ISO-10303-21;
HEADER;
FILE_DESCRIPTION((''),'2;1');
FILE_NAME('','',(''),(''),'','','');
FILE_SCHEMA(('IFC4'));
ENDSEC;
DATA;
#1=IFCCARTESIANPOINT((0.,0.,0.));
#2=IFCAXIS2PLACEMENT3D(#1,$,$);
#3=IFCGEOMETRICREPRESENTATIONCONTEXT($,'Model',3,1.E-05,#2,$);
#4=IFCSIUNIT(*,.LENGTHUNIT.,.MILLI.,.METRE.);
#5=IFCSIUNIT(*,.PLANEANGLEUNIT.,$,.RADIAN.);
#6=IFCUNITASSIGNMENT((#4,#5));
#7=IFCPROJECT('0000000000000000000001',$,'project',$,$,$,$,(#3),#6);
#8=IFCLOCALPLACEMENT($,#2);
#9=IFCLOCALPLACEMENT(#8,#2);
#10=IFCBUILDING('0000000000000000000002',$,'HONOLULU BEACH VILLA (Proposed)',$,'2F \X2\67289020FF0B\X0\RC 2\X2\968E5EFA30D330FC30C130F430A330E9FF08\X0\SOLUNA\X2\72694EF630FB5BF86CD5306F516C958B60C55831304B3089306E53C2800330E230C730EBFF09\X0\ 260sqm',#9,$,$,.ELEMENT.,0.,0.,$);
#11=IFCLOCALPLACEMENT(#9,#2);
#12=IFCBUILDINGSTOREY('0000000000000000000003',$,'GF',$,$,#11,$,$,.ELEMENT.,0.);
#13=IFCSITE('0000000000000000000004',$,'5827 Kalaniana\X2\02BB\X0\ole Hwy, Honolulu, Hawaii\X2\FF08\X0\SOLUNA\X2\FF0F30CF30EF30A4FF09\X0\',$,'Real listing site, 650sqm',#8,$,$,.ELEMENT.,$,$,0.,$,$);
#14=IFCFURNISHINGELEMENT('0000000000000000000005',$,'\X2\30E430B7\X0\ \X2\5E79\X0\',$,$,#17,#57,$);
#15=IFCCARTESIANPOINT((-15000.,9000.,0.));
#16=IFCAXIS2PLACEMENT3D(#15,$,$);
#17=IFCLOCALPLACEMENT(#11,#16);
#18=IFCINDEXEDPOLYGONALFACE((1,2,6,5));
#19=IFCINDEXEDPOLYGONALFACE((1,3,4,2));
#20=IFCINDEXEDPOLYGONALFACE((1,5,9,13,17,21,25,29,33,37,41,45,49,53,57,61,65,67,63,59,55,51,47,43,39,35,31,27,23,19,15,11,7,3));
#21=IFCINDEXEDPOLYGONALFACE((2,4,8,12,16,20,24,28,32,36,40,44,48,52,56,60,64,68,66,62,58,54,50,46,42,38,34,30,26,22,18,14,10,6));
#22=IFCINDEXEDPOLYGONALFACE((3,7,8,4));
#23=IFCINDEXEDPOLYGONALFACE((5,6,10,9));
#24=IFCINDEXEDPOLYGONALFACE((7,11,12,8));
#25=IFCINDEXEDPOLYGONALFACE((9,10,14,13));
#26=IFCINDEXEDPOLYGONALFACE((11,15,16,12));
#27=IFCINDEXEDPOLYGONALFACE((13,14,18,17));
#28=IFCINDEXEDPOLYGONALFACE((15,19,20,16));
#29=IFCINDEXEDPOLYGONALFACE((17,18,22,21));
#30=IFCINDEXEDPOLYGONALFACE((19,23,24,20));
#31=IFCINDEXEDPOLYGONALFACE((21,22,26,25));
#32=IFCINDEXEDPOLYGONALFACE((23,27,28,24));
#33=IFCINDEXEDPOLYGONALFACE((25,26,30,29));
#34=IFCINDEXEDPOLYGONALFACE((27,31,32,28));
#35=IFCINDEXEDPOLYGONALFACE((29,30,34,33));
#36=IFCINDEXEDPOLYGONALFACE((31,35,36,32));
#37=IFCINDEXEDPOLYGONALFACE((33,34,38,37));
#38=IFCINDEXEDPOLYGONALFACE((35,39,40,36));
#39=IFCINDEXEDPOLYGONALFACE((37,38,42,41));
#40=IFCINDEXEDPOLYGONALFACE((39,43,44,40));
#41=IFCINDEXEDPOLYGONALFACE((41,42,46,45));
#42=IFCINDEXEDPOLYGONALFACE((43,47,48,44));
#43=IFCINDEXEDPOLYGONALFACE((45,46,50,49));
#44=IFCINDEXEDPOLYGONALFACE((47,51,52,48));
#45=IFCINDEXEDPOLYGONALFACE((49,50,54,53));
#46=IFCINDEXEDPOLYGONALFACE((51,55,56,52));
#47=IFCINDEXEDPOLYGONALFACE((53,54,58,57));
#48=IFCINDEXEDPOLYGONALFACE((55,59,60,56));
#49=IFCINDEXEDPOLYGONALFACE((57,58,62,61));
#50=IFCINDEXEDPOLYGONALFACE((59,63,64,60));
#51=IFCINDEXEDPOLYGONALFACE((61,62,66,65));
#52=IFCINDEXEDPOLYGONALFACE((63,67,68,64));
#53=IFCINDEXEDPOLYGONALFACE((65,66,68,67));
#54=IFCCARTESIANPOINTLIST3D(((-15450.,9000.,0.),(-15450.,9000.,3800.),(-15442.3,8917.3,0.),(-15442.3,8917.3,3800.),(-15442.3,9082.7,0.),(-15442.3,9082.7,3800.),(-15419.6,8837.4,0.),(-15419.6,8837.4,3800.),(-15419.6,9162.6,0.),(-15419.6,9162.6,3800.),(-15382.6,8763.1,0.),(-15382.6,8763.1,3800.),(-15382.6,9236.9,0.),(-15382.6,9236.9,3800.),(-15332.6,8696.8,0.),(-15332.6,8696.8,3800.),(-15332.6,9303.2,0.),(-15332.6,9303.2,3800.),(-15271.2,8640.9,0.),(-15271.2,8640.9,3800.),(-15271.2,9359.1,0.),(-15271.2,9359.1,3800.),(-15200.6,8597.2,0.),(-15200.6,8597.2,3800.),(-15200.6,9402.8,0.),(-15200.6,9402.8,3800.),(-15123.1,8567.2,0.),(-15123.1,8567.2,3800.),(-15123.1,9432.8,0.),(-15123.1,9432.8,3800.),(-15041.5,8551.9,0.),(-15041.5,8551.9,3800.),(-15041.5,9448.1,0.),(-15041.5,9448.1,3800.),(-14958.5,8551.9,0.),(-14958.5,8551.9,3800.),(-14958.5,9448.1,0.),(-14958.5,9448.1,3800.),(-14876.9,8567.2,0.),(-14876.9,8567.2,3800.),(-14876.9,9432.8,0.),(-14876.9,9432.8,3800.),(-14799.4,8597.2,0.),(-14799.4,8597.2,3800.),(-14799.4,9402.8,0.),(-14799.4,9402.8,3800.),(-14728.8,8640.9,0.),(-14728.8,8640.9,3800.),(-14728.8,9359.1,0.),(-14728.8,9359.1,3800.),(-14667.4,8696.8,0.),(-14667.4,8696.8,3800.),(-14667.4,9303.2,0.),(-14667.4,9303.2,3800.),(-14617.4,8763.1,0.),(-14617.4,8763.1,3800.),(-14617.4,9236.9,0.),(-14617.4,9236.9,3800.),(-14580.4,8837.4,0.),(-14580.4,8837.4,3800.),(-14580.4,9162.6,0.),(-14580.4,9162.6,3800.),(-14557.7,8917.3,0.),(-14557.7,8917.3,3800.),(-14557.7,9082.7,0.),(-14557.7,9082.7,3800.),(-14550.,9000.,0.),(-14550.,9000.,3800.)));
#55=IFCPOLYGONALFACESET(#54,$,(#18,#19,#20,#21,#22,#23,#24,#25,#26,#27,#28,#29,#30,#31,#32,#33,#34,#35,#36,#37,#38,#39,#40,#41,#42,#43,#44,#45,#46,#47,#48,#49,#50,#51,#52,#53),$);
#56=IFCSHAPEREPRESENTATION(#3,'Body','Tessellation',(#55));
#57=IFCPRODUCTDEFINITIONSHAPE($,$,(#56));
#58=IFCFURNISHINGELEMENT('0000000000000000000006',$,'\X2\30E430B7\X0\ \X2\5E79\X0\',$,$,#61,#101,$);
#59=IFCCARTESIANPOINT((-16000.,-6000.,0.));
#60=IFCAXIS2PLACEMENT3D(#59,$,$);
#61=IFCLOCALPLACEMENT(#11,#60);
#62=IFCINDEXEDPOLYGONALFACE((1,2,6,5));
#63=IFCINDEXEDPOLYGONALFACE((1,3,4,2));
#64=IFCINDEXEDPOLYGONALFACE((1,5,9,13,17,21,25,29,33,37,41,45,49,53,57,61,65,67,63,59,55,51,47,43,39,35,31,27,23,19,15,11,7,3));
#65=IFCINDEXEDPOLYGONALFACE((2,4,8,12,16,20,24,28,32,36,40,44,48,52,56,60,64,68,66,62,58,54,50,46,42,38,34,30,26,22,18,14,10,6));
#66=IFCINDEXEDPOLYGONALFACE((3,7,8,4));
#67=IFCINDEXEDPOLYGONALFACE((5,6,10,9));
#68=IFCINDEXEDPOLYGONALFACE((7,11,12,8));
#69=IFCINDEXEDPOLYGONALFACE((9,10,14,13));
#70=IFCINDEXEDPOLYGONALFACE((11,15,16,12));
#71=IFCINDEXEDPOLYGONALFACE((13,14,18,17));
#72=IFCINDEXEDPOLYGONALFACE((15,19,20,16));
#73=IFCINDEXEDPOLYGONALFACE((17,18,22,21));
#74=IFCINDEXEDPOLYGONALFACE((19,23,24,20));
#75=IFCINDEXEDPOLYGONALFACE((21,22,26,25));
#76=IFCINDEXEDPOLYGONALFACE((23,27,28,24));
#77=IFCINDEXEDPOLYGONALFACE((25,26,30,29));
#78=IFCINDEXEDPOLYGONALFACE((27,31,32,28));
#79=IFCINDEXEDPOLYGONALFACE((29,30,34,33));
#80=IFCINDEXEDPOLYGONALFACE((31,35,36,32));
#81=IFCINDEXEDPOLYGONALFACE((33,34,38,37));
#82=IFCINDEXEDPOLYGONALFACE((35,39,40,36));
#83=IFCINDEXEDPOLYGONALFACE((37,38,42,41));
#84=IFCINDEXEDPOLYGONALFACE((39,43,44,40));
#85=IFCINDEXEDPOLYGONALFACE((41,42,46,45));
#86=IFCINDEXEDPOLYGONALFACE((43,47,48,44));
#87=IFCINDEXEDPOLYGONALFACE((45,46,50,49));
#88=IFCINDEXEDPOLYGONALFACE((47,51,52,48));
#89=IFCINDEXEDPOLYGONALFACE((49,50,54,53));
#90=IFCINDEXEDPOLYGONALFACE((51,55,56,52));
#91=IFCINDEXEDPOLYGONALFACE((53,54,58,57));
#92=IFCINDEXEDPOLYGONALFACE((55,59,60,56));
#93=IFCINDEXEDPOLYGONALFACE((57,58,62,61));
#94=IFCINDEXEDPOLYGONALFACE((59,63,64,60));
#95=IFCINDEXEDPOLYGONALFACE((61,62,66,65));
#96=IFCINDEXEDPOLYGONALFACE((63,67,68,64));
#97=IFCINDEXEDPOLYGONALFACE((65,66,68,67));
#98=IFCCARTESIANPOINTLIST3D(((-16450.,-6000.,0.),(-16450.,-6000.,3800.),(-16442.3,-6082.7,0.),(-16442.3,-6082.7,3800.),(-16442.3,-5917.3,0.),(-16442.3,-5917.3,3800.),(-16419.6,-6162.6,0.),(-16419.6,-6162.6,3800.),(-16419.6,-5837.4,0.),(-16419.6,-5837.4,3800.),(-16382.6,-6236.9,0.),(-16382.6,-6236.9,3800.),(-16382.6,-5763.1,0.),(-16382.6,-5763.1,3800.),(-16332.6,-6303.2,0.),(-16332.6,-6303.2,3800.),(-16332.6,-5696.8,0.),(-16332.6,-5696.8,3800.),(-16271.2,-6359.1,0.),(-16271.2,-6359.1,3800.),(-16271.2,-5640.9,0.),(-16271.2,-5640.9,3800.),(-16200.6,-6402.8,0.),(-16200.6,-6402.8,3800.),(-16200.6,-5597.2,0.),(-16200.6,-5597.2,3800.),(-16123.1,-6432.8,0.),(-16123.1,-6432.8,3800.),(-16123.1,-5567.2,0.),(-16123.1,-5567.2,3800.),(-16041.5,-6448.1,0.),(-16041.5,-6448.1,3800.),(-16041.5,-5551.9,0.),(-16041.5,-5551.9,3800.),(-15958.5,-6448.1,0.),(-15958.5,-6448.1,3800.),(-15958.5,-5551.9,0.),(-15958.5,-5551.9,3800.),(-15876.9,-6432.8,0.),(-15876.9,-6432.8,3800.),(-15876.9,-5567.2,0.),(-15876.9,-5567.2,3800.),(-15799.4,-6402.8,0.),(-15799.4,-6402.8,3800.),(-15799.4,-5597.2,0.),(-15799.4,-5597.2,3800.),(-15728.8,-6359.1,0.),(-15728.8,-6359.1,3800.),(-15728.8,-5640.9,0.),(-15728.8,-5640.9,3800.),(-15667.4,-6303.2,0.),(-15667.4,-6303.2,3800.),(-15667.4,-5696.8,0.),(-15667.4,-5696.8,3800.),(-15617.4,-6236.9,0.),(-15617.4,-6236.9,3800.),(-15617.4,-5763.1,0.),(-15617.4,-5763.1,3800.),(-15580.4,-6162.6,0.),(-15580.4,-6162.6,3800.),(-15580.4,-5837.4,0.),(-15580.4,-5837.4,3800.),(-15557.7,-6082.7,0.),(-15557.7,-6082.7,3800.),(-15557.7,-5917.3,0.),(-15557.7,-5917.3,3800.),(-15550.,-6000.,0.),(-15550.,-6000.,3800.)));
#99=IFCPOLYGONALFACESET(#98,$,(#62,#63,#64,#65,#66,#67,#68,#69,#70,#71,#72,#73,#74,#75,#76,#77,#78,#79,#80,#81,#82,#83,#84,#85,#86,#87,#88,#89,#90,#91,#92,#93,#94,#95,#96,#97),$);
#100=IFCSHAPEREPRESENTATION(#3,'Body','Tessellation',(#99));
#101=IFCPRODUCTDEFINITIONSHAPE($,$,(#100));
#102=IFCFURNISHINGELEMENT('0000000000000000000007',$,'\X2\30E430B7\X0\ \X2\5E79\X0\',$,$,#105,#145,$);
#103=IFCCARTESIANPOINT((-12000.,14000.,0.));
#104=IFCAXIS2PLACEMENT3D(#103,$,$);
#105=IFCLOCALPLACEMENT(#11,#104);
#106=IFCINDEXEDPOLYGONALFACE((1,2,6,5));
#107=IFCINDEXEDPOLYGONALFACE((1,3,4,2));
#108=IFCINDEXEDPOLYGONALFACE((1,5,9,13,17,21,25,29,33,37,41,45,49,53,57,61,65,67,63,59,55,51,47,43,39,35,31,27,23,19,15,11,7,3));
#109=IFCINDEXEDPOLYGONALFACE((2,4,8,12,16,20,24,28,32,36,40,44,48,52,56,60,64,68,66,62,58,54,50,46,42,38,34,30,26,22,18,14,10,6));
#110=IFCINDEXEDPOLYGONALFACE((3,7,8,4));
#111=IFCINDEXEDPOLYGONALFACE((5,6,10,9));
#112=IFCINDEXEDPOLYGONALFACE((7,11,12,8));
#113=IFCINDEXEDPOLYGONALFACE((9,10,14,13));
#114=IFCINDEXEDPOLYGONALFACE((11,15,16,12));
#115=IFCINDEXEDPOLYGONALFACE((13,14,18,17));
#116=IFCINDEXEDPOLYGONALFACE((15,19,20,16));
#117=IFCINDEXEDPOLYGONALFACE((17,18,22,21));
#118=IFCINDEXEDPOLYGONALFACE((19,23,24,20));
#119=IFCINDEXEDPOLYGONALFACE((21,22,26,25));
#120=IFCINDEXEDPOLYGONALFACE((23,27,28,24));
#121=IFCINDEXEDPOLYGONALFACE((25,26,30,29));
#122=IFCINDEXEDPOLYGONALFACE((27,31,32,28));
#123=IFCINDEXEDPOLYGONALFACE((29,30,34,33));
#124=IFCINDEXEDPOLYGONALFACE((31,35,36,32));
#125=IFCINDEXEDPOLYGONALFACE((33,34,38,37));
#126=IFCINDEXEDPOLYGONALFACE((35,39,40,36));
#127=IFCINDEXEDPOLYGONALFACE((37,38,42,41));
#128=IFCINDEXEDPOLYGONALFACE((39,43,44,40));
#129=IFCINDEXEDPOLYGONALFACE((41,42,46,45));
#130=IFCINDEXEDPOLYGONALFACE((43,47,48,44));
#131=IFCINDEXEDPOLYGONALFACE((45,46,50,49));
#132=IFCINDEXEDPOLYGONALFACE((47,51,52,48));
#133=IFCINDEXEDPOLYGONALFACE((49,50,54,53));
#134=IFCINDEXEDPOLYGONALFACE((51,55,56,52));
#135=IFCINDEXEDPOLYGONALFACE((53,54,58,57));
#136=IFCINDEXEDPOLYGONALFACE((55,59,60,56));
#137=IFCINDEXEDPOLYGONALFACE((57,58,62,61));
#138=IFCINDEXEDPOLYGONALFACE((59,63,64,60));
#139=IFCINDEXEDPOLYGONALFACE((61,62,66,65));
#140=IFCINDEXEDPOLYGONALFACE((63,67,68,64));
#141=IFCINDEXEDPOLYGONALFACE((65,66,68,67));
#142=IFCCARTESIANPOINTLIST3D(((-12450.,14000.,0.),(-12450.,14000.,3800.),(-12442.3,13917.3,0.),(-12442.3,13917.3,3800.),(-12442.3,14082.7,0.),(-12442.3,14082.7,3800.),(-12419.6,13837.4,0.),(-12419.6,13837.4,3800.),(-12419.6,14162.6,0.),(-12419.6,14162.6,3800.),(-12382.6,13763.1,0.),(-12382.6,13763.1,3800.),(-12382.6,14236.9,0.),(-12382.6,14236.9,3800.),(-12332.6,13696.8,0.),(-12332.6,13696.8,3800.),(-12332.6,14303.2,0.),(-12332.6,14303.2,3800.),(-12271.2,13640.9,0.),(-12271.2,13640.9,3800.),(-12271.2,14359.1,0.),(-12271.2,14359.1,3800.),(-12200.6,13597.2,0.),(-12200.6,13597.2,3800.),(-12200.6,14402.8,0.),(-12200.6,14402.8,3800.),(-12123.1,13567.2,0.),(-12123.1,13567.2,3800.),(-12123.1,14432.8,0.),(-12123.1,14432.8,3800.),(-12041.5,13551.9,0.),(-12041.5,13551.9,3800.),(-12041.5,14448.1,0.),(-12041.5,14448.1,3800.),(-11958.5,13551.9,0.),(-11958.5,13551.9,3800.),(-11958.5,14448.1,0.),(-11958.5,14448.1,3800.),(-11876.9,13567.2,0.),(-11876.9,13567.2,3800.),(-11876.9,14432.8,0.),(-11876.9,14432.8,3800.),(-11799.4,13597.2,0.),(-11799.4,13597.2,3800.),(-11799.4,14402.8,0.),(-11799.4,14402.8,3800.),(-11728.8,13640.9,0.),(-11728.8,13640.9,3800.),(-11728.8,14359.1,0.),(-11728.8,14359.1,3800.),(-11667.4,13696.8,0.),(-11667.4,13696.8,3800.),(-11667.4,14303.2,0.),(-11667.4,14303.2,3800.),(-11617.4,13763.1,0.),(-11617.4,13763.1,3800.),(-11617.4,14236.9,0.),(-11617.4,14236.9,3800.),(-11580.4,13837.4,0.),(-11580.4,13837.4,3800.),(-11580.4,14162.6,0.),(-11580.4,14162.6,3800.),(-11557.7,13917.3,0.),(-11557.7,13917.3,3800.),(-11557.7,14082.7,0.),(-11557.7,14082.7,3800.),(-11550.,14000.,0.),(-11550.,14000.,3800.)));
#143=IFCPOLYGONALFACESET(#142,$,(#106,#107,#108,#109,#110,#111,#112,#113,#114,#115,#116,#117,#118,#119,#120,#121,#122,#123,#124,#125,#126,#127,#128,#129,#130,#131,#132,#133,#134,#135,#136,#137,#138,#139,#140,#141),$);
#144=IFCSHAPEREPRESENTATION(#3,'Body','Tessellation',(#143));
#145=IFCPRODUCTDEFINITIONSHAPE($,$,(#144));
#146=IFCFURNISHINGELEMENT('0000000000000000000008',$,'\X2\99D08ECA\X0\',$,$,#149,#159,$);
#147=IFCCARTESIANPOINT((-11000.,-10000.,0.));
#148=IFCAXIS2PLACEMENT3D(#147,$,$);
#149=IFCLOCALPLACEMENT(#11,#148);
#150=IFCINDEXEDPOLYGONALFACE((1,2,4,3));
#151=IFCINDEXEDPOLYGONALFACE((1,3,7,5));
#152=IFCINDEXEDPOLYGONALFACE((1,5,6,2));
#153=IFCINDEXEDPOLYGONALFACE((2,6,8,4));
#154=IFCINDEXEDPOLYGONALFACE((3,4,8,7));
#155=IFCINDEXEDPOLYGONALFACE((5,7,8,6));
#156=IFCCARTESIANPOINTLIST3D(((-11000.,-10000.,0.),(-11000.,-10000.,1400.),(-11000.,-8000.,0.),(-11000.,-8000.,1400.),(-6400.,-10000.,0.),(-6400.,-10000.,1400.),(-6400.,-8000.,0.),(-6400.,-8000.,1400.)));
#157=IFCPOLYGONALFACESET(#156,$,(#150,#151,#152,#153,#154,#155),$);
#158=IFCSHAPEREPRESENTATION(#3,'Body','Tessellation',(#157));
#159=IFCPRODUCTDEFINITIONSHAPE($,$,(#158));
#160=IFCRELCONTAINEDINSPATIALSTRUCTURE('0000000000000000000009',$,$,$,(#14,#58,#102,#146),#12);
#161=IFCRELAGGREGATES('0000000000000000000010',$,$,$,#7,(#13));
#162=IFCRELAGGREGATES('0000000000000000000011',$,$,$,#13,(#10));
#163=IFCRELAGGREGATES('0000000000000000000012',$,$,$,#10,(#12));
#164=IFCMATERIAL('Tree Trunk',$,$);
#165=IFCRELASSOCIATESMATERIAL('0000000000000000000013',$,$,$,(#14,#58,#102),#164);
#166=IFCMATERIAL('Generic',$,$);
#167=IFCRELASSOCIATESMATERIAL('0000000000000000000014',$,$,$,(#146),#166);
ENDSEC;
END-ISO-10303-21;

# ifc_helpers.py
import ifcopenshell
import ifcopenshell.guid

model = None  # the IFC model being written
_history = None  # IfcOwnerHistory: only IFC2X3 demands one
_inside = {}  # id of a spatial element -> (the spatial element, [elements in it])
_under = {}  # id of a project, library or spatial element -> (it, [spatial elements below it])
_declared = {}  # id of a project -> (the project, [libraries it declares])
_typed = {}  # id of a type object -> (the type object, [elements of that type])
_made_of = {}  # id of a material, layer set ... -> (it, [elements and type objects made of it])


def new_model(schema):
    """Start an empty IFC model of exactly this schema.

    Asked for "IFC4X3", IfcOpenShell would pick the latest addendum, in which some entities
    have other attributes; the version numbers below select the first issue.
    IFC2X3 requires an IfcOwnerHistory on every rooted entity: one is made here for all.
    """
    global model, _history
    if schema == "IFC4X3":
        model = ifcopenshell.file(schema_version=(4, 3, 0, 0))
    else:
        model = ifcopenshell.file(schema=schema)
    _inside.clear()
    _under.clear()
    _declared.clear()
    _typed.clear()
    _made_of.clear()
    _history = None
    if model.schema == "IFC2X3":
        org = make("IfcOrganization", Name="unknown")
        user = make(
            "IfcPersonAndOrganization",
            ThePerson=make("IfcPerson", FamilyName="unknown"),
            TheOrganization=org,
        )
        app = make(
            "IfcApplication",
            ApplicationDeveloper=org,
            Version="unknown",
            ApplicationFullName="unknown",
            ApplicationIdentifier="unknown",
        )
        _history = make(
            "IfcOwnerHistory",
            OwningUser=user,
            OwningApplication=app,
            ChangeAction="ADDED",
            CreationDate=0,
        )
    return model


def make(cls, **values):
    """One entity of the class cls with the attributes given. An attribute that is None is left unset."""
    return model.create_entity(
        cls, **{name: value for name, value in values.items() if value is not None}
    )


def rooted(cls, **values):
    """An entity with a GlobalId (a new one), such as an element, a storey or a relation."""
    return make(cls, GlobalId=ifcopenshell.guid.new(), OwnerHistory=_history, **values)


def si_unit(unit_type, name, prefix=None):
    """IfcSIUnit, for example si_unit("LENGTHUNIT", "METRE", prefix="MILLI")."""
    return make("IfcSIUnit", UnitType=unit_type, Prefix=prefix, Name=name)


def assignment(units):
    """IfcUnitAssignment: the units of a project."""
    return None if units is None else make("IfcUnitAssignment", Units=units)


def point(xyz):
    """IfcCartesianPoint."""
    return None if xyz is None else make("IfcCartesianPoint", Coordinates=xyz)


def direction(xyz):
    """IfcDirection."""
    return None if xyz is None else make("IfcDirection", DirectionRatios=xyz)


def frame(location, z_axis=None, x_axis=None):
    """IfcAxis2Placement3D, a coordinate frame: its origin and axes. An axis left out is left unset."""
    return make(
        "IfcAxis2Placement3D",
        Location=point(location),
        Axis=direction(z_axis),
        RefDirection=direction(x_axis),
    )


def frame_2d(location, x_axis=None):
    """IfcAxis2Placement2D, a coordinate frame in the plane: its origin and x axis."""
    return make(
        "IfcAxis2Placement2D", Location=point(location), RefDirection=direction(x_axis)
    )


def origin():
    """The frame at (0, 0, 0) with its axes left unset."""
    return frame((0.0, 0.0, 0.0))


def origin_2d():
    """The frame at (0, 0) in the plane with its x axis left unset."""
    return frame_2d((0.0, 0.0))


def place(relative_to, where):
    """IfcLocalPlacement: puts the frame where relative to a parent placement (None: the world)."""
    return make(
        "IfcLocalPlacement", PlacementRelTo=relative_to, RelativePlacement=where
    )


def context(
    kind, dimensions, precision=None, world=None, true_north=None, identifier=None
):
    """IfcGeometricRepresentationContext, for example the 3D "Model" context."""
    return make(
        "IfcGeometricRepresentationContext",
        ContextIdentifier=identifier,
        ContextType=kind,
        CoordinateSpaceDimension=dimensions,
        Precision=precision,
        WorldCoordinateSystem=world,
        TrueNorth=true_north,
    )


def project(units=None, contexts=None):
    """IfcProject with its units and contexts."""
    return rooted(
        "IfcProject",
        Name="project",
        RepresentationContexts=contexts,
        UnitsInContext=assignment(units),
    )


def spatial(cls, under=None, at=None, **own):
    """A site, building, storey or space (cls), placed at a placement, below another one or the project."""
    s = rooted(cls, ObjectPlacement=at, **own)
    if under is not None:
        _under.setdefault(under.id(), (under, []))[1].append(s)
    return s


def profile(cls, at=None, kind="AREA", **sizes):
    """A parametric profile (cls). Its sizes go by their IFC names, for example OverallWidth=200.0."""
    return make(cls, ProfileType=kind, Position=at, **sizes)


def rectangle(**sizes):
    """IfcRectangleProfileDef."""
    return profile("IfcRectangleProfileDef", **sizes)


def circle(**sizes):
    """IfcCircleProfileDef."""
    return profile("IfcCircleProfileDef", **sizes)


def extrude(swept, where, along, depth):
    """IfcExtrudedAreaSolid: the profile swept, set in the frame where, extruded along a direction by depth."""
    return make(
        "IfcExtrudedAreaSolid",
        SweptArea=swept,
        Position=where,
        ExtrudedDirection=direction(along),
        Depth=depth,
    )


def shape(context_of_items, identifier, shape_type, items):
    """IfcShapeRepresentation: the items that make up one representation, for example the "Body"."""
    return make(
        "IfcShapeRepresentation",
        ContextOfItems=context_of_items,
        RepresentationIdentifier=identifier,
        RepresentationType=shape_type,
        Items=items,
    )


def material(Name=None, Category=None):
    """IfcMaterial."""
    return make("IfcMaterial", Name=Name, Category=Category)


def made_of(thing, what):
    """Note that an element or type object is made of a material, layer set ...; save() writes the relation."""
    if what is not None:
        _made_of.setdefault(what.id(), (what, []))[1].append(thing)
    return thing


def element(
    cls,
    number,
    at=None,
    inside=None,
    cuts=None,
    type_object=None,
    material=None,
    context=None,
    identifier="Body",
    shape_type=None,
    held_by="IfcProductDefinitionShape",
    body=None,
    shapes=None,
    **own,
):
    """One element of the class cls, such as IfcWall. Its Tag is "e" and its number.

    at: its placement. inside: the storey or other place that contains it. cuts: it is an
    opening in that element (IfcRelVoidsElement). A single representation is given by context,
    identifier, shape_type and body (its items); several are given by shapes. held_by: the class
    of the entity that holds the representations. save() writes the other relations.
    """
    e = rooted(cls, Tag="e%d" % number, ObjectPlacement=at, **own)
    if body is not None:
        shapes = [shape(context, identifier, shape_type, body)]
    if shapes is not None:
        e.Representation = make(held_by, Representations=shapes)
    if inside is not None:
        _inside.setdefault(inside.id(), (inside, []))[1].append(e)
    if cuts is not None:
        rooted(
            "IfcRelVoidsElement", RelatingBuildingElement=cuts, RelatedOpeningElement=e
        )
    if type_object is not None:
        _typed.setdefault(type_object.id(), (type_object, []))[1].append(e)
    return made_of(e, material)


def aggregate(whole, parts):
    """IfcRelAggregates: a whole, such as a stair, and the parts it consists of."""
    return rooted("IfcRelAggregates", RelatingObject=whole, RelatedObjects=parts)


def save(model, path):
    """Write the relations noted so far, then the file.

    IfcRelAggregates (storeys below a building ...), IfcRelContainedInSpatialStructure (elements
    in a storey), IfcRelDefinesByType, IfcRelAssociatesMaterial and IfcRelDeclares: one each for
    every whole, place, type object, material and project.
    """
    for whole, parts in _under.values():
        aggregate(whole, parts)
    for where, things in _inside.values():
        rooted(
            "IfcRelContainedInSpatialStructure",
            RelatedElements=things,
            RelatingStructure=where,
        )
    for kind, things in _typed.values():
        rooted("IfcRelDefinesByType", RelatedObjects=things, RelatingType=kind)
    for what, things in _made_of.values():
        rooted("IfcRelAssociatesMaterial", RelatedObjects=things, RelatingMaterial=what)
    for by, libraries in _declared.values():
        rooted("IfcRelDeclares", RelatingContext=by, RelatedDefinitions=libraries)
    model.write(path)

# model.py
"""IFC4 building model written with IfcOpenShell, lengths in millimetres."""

from ifc_helpers import new_model, si_unit, frame, frame_2d, origin, origin_2d, place, context, project, spatial, rectangle, circle, extrude, material, element, save


model = new_model("IFC4")

# Units and contexts
model_context = context("Model", 3, precision=1e-05, world=origin())
ifc_project = project(units=[si_unit("LENGTHUNIT", "METRE", prefix="MILLI"), si_unit("PLANEANGLEUNIT", "RADIAN")], contexts=[model_context])

# Site, building, storey
site_placement = place(None, origin())
site = spatial("IfcSite", under=ifc_project, at=site_placement, Name="5827 Kalanianaʻole Hwy, Honolulu, Hawaii（SOLUNA／ハワイ）", ObjectType="Real listing site, 650sqm", CompositionType="ELEMENT", RefElevation=0.0)
building_placement = place(site_placement, origin())
building = spatial("IfcBuilding", under=site, at=building_placement, Name="HONOLULU BEACH VILLA (Proposed)", ObjectType="2F 木造＋RC 2階建ビーチヴィラ（SOLUNA物件・寸法は公開情報からの参考モデル） 260sqm", CompositionType="ELEMENT", ElevationOfRefHeight=0.0, ElevationOfTerrain=0.0)
storey_placement = place(building_placement, origin())
storey = spatial("IfcBuildingStorey", under=building, at=storey_placement, Name="GF", CompositionType="ELEMENT", Elevation=0.0)

# Shared definitions
ifc_material_1 = material(Name="Generic")

# Furnishing elements
ifc_material_2 = material(Name="Tree Trunk")
furnishing_1_placement = place(storey_placement, frame((-15000.0, 9000.0, 0.0)))
element("IfcFurnishingElement", 1, at=furnishing_1_placement, inside=storey, material=ifc_material_2, Name="ヤシ 幹", context=model_context, shape_type="SweptSolid", body=[
    extrude(circle(Radius=450.0, at=origin_2d()), frame((-15000.0, 9000.0, 0.0)), (0.0, 0.0, 1.0), 3800.0),
])
furnishing_2_placement = place(storey_placement, frame((-16000.0, -6000.0, 0.0)))
element("IfcFurnishingElement", 2, at=furnishing_2_placement, inside=storey, material=ifc_material_2, Name="ヤシ 幹", context=model_context, shape_type="SweptSolid", body=[
    extrude(circle(Radius=450.0, at=origin_2d()), frame((-16000.0, -6000.0, 0.0)), (0.0, 0.0, 1.0), 3800.0),
])
furnishing_3_placement = place(storey_placement, frame((-12000.0, 14000.0, 0.0)))
element("IfcFurnishingElement", 3, at=furnishing_3_placement, inside=storey, material=ifc_material_2, Name="ヤシ 幹", context=model_context, shape_type="SweptSolid", body=[
    extrude(circle(Radius=450.0, at=origin_2d()), frame((-12000.0, 14000.0, 0.0)), (0.0, 0.0, 1.0), 3800.0),
])
furnishing_4_placement = place(storey_placement, frame((-11000.0, -10000.0, 0.0)))
element("IfcFurnishingElement", 4, at=furnishing_4_placement, inside=storey, material=ifc_material_1, Name="駐車", context=model_context, shape_type="SweptSolid", body=[
    extrude(rectangle(XDim=4600.0, YDim=2000.0, at=frame_2d((2300.0, 1000.0))), frame((-11000.0, -10000.0, 0.0)), (0.0, 0.0, 1.0), 1400.0),
])

save(model, "model.ifc")
